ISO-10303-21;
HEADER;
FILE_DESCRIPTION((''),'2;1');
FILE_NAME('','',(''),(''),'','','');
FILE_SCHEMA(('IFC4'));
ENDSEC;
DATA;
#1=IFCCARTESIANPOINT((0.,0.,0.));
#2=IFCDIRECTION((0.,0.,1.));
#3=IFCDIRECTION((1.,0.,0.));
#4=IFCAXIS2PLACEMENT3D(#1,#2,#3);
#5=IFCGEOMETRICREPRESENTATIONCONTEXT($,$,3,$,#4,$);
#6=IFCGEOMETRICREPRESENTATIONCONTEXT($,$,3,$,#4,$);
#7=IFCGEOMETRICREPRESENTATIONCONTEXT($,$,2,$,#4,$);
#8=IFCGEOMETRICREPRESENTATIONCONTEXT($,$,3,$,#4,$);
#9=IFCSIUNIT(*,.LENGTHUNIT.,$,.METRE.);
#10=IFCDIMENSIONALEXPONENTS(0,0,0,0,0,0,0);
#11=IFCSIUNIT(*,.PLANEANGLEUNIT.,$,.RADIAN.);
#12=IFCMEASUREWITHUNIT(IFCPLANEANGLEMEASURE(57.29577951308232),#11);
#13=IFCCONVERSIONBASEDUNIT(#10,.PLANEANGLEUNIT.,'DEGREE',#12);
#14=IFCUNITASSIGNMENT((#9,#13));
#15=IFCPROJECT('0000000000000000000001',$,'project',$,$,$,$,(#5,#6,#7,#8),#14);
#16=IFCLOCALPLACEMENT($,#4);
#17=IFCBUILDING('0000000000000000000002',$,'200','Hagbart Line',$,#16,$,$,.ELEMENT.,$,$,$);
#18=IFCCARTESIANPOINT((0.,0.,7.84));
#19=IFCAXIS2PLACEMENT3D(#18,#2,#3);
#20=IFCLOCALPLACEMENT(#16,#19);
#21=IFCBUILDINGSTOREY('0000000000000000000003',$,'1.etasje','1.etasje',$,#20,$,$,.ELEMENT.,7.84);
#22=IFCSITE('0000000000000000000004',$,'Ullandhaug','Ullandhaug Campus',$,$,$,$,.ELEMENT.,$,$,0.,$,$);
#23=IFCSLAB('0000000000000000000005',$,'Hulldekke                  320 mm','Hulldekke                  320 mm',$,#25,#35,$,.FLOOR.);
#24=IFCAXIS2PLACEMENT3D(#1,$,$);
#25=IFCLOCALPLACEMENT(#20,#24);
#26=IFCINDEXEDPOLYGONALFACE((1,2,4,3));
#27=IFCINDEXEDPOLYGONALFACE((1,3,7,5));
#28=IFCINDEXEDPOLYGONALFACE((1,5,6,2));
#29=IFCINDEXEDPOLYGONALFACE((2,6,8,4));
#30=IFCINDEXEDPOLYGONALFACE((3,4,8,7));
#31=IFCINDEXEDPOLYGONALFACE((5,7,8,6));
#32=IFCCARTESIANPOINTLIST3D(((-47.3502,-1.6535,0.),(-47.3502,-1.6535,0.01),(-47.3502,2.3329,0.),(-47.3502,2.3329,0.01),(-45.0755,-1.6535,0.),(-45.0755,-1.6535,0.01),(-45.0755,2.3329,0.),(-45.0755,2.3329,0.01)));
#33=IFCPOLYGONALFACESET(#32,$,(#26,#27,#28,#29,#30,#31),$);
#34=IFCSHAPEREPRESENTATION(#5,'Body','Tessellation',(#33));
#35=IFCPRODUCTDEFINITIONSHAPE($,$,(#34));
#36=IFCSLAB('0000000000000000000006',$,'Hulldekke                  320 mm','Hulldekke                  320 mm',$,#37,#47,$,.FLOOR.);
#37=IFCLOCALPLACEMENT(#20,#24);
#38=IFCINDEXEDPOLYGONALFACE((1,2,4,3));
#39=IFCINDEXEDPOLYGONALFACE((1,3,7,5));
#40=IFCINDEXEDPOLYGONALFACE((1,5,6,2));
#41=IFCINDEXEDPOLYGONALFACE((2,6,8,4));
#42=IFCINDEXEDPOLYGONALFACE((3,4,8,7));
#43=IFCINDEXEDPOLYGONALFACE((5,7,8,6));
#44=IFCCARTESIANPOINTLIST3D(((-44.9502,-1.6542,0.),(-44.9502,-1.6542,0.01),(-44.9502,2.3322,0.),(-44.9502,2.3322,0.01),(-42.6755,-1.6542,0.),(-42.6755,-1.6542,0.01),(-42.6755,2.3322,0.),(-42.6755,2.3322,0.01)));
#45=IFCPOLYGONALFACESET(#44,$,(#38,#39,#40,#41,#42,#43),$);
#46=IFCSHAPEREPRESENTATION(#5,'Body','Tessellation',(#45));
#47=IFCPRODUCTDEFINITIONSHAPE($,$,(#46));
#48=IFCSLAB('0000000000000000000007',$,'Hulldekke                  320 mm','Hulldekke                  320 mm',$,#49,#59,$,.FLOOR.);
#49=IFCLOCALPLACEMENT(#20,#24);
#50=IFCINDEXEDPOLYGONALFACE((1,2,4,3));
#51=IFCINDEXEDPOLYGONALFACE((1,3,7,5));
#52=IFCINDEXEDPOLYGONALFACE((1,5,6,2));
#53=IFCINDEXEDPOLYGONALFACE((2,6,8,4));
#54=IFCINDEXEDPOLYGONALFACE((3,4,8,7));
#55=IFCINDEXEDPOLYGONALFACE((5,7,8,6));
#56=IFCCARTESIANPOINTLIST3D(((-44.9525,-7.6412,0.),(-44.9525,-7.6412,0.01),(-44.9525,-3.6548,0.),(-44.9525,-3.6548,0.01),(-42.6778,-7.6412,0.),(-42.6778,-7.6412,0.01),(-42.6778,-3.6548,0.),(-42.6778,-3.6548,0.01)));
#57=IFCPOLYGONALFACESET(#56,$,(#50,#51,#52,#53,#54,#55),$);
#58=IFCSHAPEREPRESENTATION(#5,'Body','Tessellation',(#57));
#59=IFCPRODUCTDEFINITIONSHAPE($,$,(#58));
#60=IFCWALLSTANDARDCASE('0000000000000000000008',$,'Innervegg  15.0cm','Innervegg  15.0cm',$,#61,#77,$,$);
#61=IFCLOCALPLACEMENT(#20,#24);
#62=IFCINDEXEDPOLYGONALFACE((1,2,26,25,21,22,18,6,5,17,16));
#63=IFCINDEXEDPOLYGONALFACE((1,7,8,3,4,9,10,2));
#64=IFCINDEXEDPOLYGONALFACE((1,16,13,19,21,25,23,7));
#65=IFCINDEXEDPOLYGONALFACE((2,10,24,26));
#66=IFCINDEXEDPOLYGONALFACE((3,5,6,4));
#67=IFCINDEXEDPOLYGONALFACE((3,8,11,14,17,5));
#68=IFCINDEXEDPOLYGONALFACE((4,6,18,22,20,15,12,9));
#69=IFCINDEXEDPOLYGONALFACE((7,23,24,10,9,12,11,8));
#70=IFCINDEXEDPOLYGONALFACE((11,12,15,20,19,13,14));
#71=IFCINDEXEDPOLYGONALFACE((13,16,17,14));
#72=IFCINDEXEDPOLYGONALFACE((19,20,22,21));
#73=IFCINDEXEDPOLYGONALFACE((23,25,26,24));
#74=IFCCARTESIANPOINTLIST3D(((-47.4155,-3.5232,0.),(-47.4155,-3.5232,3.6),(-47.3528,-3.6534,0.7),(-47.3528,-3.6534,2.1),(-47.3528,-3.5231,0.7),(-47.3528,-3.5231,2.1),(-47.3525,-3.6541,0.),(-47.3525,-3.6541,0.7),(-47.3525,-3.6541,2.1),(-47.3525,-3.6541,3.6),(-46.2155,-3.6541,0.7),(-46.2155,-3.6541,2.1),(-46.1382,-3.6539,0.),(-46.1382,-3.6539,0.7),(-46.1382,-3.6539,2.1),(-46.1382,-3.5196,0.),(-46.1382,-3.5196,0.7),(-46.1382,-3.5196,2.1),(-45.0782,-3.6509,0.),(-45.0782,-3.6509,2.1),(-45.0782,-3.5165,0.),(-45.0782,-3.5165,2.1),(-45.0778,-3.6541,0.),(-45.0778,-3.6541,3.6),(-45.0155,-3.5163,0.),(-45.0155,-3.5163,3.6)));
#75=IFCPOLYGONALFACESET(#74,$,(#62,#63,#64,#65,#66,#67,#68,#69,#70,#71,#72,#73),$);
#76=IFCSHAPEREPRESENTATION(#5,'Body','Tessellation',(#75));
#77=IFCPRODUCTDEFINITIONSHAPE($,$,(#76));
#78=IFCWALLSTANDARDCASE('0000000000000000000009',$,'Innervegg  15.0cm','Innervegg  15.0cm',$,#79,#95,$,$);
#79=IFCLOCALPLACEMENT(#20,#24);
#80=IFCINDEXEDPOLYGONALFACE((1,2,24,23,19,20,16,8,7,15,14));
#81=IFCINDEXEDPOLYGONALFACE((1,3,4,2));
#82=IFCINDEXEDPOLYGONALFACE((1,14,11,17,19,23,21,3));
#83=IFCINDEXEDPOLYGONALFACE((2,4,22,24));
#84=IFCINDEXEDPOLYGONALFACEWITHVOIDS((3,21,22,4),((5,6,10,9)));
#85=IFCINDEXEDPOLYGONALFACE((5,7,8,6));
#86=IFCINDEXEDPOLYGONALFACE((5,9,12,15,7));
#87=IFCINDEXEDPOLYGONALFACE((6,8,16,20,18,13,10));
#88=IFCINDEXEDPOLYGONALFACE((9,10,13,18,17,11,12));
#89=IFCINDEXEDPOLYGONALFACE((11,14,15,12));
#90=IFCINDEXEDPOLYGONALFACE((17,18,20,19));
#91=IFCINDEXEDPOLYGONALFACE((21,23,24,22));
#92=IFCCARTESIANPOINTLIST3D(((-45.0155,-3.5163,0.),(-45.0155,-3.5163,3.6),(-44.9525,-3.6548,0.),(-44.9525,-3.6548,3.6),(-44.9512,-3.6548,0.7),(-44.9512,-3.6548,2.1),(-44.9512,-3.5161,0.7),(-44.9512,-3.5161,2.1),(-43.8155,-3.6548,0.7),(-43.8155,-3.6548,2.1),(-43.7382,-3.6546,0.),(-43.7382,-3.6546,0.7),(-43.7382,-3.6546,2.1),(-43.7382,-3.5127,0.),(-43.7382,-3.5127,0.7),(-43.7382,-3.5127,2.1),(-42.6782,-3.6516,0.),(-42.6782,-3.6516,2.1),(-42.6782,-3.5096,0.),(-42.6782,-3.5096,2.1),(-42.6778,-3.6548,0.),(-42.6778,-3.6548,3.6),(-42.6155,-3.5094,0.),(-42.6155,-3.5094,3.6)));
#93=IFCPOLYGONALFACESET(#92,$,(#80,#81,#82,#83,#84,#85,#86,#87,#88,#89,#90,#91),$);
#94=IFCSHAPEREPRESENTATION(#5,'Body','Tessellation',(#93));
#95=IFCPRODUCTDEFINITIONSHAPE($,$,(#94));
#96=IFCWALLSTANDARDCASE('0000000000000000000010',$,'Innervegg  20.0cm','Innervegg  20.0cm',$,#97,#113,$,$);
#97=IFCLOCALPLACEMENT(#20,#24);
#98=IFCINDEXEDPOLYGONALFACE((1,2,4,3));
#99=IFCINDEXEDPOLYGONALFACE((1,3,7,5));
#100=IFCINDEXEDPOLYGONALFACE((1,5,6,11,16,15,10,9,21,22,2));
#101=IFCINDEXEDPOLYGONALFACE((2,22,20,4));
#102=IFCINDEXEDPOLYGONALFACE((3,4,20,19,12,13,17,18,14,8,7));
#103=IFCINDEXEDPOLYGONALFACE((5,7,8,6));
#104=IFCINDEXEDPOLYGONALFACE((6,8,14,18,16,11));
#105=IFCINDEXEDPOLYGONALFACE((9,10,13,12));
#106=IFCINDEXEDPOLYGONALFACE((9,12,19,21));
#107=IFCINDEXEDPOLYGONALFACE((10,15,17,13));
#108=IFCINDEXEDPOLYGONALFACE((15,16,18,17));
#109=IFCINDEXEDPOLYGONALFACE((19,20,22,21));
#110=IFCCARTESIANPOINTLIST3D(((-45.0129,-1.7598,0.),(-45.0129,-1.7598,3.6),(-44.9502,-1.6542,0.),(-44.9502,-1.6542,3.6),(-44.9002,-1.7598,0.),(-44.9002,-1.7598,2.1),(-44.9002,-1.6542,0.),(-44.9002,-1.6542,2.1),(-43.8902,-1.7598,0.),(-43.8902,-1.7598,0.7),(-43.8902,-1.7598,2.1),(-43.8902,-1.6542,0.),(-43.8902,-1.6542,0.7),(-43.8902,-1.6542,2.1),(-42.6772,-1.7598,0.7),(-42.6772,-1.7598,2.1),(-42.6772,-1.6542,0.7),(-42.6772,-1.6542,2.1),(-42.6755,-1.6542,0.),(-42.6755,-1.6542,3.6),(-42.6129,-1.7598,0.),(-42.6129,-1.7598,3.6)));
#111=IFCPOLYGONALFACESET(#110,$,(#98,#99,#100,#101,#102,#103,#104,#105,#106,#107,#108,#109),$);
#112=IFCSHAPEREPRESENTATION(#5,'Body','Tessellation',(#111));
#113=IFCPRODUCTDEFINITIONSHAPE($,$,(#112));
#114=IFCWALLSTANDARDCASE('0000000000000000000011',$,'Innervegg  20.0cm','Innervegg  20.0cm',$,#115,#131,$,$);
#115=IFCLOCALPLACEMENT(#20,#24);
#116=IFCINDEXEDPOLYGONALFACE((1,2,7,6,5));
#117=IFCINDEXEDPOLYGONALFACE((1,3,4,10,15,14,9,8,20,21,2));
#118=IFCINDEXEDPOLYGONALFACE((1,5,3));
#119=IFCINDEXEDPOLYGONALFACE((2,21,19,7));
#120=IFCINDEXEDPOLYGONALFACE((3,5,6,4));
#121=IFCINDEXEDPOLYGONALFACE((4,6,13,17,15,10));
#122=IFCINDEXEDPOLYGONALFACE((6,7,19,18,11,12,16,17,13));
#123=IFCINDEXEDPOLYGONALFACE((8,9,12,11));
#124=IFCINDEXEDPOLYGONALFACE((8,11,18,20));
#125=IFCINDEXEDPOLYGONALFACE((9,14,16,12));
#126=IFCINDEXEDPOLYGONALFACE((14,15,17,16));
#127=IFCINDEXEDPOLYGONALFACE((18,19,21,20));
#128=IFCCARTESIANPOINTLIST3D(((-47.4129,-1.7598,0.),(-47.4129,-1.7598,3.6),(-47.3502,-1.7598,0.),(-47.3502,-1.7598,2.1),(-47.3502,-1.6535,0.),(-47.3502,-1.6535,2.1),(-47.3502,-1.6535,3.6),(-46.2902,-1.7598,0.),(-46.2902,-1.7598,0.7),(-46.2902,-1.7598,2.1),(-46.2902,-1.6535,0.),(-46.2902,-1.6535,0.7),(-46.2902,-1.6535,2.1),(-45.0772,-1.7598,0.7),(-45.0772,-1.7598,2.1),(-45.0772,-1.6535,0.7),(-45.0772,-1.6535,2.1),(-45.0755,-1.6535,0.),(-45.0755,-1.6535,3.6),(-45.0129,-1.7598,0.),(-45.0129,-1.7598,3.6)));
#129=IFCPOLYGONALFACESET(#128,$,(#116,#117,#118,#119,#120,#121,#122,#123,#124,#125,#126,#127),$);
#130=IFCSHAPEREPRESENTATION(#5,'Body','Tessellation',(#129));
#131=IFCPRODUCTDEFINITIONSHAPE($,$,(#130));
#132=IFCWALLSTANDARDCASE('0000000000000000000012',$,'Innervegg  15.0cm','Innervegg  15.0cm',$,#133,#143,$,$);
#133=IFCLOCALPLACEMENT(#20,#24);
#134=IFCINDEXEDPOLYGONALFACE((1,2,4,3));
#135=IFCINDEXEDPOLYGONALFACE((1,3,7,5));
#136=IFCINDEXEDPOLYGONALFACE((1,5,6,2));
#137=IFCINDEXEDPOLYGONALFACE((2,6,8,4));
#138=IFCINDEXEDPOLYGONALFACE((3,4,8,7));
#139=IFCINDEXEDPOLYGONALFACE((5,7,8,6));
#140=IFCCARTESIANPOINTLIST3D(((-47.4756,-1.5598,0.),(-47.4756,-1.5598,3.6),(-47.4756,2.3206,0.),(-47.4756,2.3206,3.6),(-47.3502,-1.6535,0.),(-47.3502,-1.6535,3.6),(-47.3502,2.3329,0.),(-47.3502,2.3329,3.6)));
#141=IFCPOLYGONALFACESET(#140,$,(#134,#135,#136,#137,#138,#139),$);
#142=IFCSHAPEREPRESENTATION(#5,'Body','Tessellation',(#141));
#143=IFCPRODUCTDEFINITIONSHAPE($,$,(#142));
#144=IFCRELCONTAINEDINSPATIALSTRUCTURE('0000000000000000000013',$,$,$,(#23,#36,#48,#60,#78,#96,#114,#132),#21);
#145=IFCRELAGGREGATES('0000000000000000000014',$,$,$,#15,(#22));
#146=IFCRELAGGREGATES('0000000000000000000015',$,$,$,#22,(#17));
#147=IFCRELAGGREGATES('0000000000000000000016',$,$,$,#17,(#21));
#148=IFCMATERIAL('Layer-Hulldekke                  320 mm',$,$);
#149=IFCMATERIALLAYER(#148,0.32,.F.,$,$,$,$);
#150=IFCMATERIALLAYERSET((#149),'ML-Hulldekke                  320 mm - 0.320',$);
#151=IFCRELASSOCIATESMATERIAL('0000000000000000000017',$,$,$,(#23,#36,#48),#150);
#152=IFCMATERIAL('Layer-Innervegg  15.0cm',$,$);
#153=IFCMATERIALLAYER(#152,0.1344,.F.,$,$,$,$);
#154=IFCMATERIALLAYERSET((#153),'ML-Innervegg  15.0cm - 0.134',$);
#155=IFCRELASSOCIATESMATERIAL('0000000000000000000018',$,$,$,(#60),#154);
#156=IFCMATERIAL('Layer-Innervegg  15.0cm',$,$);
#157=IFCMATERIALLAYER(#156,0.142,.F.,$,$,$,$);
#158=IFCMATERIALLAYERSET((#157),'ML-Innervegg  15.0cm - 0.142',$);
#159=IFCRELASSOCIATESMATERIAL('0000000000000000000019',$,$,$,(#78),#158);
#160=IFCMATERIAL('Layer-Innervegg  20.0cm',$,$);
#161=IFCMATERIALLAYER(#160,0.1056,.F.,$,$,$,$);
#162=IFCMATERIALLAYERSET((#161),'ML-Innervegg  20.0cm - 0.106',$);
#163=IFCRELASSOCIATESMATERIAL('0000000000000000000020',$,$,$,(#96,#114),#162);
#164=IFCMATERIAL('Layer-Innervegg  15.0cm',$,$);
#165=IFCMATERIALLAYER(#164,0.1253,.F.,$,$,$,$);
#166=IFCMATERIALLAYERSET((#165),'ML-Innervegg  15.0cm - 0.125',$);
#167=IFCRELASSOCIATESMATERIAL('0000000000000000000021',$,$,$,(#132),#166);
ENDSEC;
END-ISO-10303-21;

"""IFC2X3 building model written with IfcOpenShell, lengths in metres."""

from ifc_helpers import new_model, entity, si_unit, converted_unit, frame, origin_with_axes, place, context, project, spatial, polyline, outline, extrude, material, layer, layer_set, layer_usage, element, save


model = new_model("IFC2X3")

# Units and contexts
context_of_model_1 = context(None, 3, world=origin_with_axes())
context_of_model_2 = context(None, 3, world=origin_with_axes())
context_of_model_3 = context(None, 2, world=origin_with_axes())
context_of_model_4 = context(None, 3, world=origin_with_axes())
ifc_project = project(units=[si_unit("LENGTHUNIT", "METRE"), converted_unit("PLANEANGLEUNIT", "DEGREE", entity("IfcPlaneAngleMeasure", 57.29577951308232), si_unit("PLANEANGLEUNIT", "RADIAN"), dimensions=[0, 0, 0, 0, 0, 0, 0])], contexts=[context_of_model_1, context_of_model_2, context_of_model_3, context_of_model_4])

# Site, building, storey
site = spatial("IfcSite", under=ifc_project, Name="Ullandhaug", Description="Ullandhaug Campus", CompositionType="ELEMENT", RefElevation=0.0)
building_placement = place(None, origin_with_axes())
building = spatial("IfcBuilding", under=site, at=building_placement, Name="200", Description="Hagbart Line", CompositionType="ELEMENT")
storey_placement = place(building_placement, frame((0.0, 0.0, 7.84), z_axis=(0.0, 0.0, 1.0), x_axis=(1.0, 0.0, 0.0)))
storey = spatial("IfcBuildingStorey", under=building, at=storey_placement, Name="1.etasje", Description="1.etasje", CompositionType="ELEMENT", Elevation=7.84)

# Slabs
ifc_material_1 = material(Name="Layer-Hulldekke                  320 mm")
ifc_layer_1 = layer(ifc_material_1, 0.32, ventilated=False)
ifc_layer_set_1 = layer_set([ifc_layer_1], Name="ML-Hulldekke                  320 mm - 0.320")
ifc_layer_usage_1 = layer_usage(ifc_layer_set_1, "AXIS2", "POSITIVE", 0.0)
slab_1_placement = place(storey_placement, frame((-47.3502, -1.6535, 0.0), z_axis=(0.0, 0.0, 1.0), x_axis=(1.0, 0.0, 0.0)))
element("IfcSlab", 1, at=slab_1_placement, inside=storey, material=ifc_layer_usage_1, Name="Hulldekke                  320 mm", Description="Hulldekke                  320 mm", PredefinedType="FLOOR", context=context_of_model_1, shape_type="SweptSolid", body=[
    extrude(outline(polyline([(0.0, 0.0), (2.2747, 0.0), (2.2747, 3.9863), (0.0, 3.9863), (0.0, 0.0)])), origin_with_axes(), (0.0, 0.0, 1.0), 0.01),
])
slab_2_placement = place(storey_placement, frame((-44.9502, -1.6542, 0.0), z_axis=(0.0, 0.0, 1.0), x_axis=(1.0, 0.0, 0.0)))
element("IfcSlab", 2, at=slab_2_placement, inside=storey, material=ifc_layer_usage_1, Name="Hulldekke                  320 mm", Description="Hulldekke                  320 mm", PredefinedType="FLOOR", context=context_of_model_1, shape_type="SweptSolid", body=[
    extrude(outline(polyline([(0.0, 0.0), (2.2747, 0.0), (2.2747, 3.9863), (0.0, 3.9863), (0.0, 0.0)])), origin_with_axes(), (0.0, 0.0, 1.0), 0.01),
])
slab_3_placement = place(storey_placement, frame((-44.9525, -7.6412, 0.0), z_axis=(0.0, 0.0, 1.0), x_axis=(1.0, 0.0, 0.0)))
element("IfcSlab", 3, at=slab_3_placement, inside=storey, material=ifc_layer_usage_1, Name="Hulldekke                  320 mm", Description="Hulldekke                  320 mm", PredefinedType="FLOOR", context=context_of_model_1, shape_type="SweptSolid", body=[
    extrude(outline(polyline([(0.0, 0.0), (2.2747, 0.0), (2.2747, 3.9863), (0.0, 3.9863), (0.0, 0.0)])), origin_with_axes(), (0.0, 0.0, 1.0), 0.01),
])

# Walls, openings
ifc_material_2 = material(Name="Layer-Innervegg  15.0cm")
ifc_layer_2 = layer(ifc_material_2, 0.1344, ventilated=False)
ifc_layer_set_2 = layer_set([ifc_layer_2], Name="ML-Innervegg  15.0cm - 0.134")
ifc_layer_usage_2 = layer_usage(ifc_layer_set_2, "AXIS2", "POSITIVE", 0.0)
wall_1_placement = place(storey_placement, frame((-47.3525, -3.6541, 0.0), z_axis=(0.0, 0.0, 1.0), x_axis=(1.0, 0.0, 0.0)))
wall_1 = element("IfcWallStandardCase", 4, at=wall_1_placement, inside=storey, material=ifc_layer_usage_2, Name="Innervegg  15.0cm", Description="Innervegg  15.0cm", context=context_of_model_1, shape_type="SweptSolid", body=[
    extrude(outline(polyline([(0.0, 0.0), (2.2747, 0.0), (2.3369, 0.1378), (-0.063, 0.1309), (0.0, 0.0)])), origin_with_axes(), (0.0, 0.0, 1.0), 3.6),
])
opening_1_placement = place(wall_1_placement, frame((1.2143, 0.1346, 0.0), z_axis=(0.0, 0.0, 1.0), x_axis=(1.0, 0.0, 0.0)))
element("IfcOpeningElement", 5, at=opening_1_placement, cuts=wall_1, context=context_of_model_1, shape_type="SweptSolid", body=[
    extrude(outline(polyline([(0.0, 0.0), (2.1, 0.0), (2.1, 1.06), (0.0, 1.06), (0.0, 0.0)])), frame((0.0, 0.0, 0.0), z_axis=(-0.002878, 0.999996, 0.0), x_axis=(0.0, 0.0, 1.0)), (0.0, -0.002878, -0.999996), 0.1344),
])
opening_2_placement = place(wall_1_placement, frame((-0.0004, 0.1311, 0.7), z_axis=(0.0, 0.0, 1.0), x_axis=(1.0, 0.0, 0.0)))
element("IfcOpeningElement", 6, at=opening_2_placement, cuts=wall_1, context=context_of_model_1, shape_type="SweptSolid", body=[
    extrude(outline(polyline([(0.0, 0.0), (1.4, 0.0), (1.4, 1.2147), (0.0, 1.2147), (0.0, 0.0)])), frame((0.0, 0.0, 0.0), z_axis=(-0.002878, 0.999996, 0.0), x_axis=(0.0, 0.0, 1.0)), (0.0, -0.002878, -0.999996), 0.1344),
])
ifc_material_3 = material(Name="Layer-Innervegg  15.0cm")
ifc_layer_3 = layer(ifc_material_3, 0.142, ventilated=False)
ifc_layer_set_3 = layer_set([ifc_layer_3], Name="ML-Innervegg  15.0cm - 0.142")
ifc_layer_usage_3 = layer_usage(ifc_layer_set_3, "AXIS2", "POSITIVE", 0.0)
wall_2_placement = place(storey_placement, frame((-44.9525, -3.6548, 0.0), z_axis=(0.0, 0.0, 1.0), x_axis=(1.0, 0.0, 0.0)))
wall_2 = element("IfcWallStandardCase", 7, at=wall_2_placement, inside=storey, material=ifc_layer_usage_3, Name="Innervegg  15.0cm", Description="Innervegg  15.0cm", context=context_of_model_1, shape_type="SweptSolid", body=[
    extrude(outline(polyline([(0.0, 0.0), (2.2747, 0.0), (2.3369, 0.1454), (-0.0631, 0.1385), (0.0, 0.0)])), origin_with_axes(), (0.0, 0.0, 1.0), 3.6),
])
opening_3_placement = place(wall_2_placement, frame((1.2143, 0.1422, 0.0), z_axis=(0.0, 0.0, 1.0), x_axis=(1.0, 0.0, 0.0)))
element("IfcOpeningElement", 8, at=opening_3_placement, cuts=wall_2, context=context_of_model_1, shape_type="SweptSolid", body=[
    extrude(outline(polyline([(0.0, 0.0), (2.1, 0.0), (2.1, 1.06), (0.0, 1.06), (0.0, 0.0)])), frame((0.0, 0.0, 0.0), z_axis=(-0.002878, 0.999996, 0.0), x_axis=(0.0, 0.0, 1.0)), (0.0, -0.002878, -0.999996), 0.142),
])
opening_4_placement = place(wall_2_placement, frame((0.0013, 0.1387, 0.7), z_axis=(0.0, 0.0, 1.0), x_axis=(1.0, 0.0, 0.0)))
element("IfcOpeningElement", 9, at=opening_4_placement, cuts=wall_2, context=context_of_model_1, shape_type="SweptSolid", body=[
    extrude(outline(polyline([(0.0, 0.0), (1.4, 0.0), (1.4, 1.213), (0.0, 1.213), (0.0, 0.0)])), frame((0.0, 0.0, 0.0), z_axis=(-0.002878, 0.999996, 0.0), x_axis=(0.0, 0.0, 1.0)), (0.0, -0.002878, -0.999996), 0.142),
])
ifc_material_4 = material(Name="Layer-Innervegg  20.0cm")
ifc_layer_4 = layer(ifc_material_4, 0.1056, ventilated=False)
ifc_layer_set_4 = layer_set([ifc_layer_4], Name="ML-Innervegg  20.0cm - 0.106")
ifc_layer_usage_4 = layer_usage(ifc_layer_set_4, "AXIS2", "POSITIVE", 0.0)
wall_3_placement = place(storey_placement, frame((-42.6755, -1.6542, 0.0), z_axis=(0.0, 0.0, 1.0), x_axis=(-1.0, 0.0, 0.0)))
wall_3 = element("IfcWallStandardCase", 10, at=wall_3_placement, inside=storey, material=ifc_layer_usage_4, Name="Innervegg  20.0cm", Description="Innervegg  20.0cm", context=context_of_model_1, shape_type="SweptSolid", body=[
    extrude(outline(polyline([(0.0, 0.0), (2.2747, 0.0), (2.3373, 0.1056), (-0.0627, 0.1056), (0.0, 0.0)])), frame((0.0, 0.0, 0.0), z_axis=(0.0, 0.0, 1.0), x_axis=(1.0, 0.0, 0.0)), (0.0, 0.0, 1.0), 3.6),
])
opening_5_placement = place(wall_3_placement, frame((0.0017, 0.1056, 0.7), z_axis=(0.0, 0.0, 1.0), x_axis=(1.0, 0.0, 0.0)))
element("IfcOpeningElement", 11, at=opening_5_placement, cuts=wall_3, context=context_of_model_1, shape_type="SweptSolid", body=[
    extrude(outline(polyline([(0.0, 0.0), (1.4, 0.0), (1.4, 1.213), (0.0, 1.213), (0.0, 0.0)])), frame((0.0, 0.0, 0.0), z_axis=(0.0, 1.0, 0.0), x_axis=(0.0, 0.0, 1.0)), (0.0, 0.0, -1.0), 0.1056),
])
opening_6_placement = place(wall_3_placement, frame((1.2147, 0.1056, 0.0), z_axis=(0.0, 0.0, 1.0), x_axis=(1.0, 0.0, 0.0)))
element("IfcOpeningElement", 12, at=opening_6_placement, cuts=wall_3, context=context_of_model_1, shape_type="SweptSolid", body=[
    extrude(outline(polyline([(0.0, 0.0), (2.1, 0.0), (2.1, 1.01), (0.0, 1.01), (0.0, 0.0)])), frame((0.0, 0.0, 0.0), z_axis=(0.0, 1.0, 0.0), x_axis=(0.0, 0.0, 1.0)), (0.0, 0.0, -1.0), 0.1056),
])
wall_4_placement = place(storey_placement, frame((-45.0755, -1.6535, 0.0), z_axis=(0.0, 0.0, 1.0), x_axis=(-1.0, 0.0, 0.0)))
wall_4 = element("IfcWallStandardCase", 13, at=wall_4_placement, inside=storey, material=ifc_layer_usage_4, Name="Innervegg  20.0cm", Description="Innervegg  20.0cm", context=context_of_model_1, shape_type="SweptSolid", body=[
    extrude(outline(polyline([(0.0, 0.0), (2.2747, 0.0), (2.3373, 0.1063), (-0.0627, 0.1063), (0.0, 0.0)])), frame((0.0, 0.0, 0.0), z_axis=(0.0, 0.0, 1.0), x_axis=(1.0, 0.0, 0.0)), (0.0, 0.0, 1.0), 3.6),
])
opening_7_placement = place(wall_4_placement, frame((1.2147, 0.1063, 0.0), z_axis=(0.0, 0.0, 1.0), x_axis=(1.0, 0.0, 0.0)))
element("IfcOpeningElement", 14, at=opening_7_placement, cuts=wall_4, context=context_of_model_1, shape_type="SweptSolid", body=[
    extrude(outline(polyline([(0.0, 0.0), (2.1, 0.0), (2.1, 1.06), (0.0, 1.06), (0.0, 0.0)])), frame((0.0, 0.0, 0.0), z_axis=(0.0, 1.0, 0.0), x_axis=(0.0, 0.0, 1.0)), (0.0, 0.0, -1.0), 0.1063),
])
opening_8_placement = place(wall_4_placement, frame((0.0017, 0.1063, 0.7), z_axis=(0.0, 0.0, 1.0), x_axis=(1.0, 0.0, 0.0)))
element("IfcOpeningElement", 15, at=opening_8_placement, cuts=wall_4, context=context_of_model_1, shape_type="SweptSolid", body=[
    extrude(outline(polyline([(0.0, 0.0), (1.4, 0.0), (1.4, 1.213), (0.0, 1.213), (0.0, 0.0)])), frame((0.0, 0.0, 0.0), z_axis=(0.0, 1.0, 0.0), x_axis=(0.0, 0.0, 1.0)), (0.0, 0.0, -1.0), 0.1063),
])

# Wall
ifc_material_5 = material(Name="Layer-Innervegg  15.0cm")
ifc_layer_5 = layer(ifc_material_5, 0.1253, ventilated=False)
ifc_layer_set_5 = layer_set([ifc_layer_5], Name="ML-Innervegg  15.0cm - 0.125")
ifc_layer_usage_5 = layer_usage(ifc_layer_set_5, "AXIS2", "POSITIVE", 0.0)
wall_5_placement = place(storey_placement, frame((-47.3502, -1.6535, 0.0), z_axis=(0.0, 0.0, 1.0), x_axis=(0.0, 1.0, 0.0)))
element("IfcWallStandardCase", 16, at=wall_5_placement, inside=storey, material=ifc_layer_usage_5, Name="Innervegg  15.0cm", Description="Innervegg  15.0cm", context=context_of_model_1, shape_type="SweptSolid", body=[
    extrude(outline(polyline([(0.0, 0.0), (3.9863, 0.0), (3.974, 0.1253), (0.0937, 0.1253), (0.0, 0.0)])), frame((0.0, 0.0, 0.0), z_axis=(0.0, 0.0, 1.0), x_axis=(1.0, 0.0, 0.0)), (0.0, 0.0, 1.0), 3.6),
])

save(model, "model.ifc")
